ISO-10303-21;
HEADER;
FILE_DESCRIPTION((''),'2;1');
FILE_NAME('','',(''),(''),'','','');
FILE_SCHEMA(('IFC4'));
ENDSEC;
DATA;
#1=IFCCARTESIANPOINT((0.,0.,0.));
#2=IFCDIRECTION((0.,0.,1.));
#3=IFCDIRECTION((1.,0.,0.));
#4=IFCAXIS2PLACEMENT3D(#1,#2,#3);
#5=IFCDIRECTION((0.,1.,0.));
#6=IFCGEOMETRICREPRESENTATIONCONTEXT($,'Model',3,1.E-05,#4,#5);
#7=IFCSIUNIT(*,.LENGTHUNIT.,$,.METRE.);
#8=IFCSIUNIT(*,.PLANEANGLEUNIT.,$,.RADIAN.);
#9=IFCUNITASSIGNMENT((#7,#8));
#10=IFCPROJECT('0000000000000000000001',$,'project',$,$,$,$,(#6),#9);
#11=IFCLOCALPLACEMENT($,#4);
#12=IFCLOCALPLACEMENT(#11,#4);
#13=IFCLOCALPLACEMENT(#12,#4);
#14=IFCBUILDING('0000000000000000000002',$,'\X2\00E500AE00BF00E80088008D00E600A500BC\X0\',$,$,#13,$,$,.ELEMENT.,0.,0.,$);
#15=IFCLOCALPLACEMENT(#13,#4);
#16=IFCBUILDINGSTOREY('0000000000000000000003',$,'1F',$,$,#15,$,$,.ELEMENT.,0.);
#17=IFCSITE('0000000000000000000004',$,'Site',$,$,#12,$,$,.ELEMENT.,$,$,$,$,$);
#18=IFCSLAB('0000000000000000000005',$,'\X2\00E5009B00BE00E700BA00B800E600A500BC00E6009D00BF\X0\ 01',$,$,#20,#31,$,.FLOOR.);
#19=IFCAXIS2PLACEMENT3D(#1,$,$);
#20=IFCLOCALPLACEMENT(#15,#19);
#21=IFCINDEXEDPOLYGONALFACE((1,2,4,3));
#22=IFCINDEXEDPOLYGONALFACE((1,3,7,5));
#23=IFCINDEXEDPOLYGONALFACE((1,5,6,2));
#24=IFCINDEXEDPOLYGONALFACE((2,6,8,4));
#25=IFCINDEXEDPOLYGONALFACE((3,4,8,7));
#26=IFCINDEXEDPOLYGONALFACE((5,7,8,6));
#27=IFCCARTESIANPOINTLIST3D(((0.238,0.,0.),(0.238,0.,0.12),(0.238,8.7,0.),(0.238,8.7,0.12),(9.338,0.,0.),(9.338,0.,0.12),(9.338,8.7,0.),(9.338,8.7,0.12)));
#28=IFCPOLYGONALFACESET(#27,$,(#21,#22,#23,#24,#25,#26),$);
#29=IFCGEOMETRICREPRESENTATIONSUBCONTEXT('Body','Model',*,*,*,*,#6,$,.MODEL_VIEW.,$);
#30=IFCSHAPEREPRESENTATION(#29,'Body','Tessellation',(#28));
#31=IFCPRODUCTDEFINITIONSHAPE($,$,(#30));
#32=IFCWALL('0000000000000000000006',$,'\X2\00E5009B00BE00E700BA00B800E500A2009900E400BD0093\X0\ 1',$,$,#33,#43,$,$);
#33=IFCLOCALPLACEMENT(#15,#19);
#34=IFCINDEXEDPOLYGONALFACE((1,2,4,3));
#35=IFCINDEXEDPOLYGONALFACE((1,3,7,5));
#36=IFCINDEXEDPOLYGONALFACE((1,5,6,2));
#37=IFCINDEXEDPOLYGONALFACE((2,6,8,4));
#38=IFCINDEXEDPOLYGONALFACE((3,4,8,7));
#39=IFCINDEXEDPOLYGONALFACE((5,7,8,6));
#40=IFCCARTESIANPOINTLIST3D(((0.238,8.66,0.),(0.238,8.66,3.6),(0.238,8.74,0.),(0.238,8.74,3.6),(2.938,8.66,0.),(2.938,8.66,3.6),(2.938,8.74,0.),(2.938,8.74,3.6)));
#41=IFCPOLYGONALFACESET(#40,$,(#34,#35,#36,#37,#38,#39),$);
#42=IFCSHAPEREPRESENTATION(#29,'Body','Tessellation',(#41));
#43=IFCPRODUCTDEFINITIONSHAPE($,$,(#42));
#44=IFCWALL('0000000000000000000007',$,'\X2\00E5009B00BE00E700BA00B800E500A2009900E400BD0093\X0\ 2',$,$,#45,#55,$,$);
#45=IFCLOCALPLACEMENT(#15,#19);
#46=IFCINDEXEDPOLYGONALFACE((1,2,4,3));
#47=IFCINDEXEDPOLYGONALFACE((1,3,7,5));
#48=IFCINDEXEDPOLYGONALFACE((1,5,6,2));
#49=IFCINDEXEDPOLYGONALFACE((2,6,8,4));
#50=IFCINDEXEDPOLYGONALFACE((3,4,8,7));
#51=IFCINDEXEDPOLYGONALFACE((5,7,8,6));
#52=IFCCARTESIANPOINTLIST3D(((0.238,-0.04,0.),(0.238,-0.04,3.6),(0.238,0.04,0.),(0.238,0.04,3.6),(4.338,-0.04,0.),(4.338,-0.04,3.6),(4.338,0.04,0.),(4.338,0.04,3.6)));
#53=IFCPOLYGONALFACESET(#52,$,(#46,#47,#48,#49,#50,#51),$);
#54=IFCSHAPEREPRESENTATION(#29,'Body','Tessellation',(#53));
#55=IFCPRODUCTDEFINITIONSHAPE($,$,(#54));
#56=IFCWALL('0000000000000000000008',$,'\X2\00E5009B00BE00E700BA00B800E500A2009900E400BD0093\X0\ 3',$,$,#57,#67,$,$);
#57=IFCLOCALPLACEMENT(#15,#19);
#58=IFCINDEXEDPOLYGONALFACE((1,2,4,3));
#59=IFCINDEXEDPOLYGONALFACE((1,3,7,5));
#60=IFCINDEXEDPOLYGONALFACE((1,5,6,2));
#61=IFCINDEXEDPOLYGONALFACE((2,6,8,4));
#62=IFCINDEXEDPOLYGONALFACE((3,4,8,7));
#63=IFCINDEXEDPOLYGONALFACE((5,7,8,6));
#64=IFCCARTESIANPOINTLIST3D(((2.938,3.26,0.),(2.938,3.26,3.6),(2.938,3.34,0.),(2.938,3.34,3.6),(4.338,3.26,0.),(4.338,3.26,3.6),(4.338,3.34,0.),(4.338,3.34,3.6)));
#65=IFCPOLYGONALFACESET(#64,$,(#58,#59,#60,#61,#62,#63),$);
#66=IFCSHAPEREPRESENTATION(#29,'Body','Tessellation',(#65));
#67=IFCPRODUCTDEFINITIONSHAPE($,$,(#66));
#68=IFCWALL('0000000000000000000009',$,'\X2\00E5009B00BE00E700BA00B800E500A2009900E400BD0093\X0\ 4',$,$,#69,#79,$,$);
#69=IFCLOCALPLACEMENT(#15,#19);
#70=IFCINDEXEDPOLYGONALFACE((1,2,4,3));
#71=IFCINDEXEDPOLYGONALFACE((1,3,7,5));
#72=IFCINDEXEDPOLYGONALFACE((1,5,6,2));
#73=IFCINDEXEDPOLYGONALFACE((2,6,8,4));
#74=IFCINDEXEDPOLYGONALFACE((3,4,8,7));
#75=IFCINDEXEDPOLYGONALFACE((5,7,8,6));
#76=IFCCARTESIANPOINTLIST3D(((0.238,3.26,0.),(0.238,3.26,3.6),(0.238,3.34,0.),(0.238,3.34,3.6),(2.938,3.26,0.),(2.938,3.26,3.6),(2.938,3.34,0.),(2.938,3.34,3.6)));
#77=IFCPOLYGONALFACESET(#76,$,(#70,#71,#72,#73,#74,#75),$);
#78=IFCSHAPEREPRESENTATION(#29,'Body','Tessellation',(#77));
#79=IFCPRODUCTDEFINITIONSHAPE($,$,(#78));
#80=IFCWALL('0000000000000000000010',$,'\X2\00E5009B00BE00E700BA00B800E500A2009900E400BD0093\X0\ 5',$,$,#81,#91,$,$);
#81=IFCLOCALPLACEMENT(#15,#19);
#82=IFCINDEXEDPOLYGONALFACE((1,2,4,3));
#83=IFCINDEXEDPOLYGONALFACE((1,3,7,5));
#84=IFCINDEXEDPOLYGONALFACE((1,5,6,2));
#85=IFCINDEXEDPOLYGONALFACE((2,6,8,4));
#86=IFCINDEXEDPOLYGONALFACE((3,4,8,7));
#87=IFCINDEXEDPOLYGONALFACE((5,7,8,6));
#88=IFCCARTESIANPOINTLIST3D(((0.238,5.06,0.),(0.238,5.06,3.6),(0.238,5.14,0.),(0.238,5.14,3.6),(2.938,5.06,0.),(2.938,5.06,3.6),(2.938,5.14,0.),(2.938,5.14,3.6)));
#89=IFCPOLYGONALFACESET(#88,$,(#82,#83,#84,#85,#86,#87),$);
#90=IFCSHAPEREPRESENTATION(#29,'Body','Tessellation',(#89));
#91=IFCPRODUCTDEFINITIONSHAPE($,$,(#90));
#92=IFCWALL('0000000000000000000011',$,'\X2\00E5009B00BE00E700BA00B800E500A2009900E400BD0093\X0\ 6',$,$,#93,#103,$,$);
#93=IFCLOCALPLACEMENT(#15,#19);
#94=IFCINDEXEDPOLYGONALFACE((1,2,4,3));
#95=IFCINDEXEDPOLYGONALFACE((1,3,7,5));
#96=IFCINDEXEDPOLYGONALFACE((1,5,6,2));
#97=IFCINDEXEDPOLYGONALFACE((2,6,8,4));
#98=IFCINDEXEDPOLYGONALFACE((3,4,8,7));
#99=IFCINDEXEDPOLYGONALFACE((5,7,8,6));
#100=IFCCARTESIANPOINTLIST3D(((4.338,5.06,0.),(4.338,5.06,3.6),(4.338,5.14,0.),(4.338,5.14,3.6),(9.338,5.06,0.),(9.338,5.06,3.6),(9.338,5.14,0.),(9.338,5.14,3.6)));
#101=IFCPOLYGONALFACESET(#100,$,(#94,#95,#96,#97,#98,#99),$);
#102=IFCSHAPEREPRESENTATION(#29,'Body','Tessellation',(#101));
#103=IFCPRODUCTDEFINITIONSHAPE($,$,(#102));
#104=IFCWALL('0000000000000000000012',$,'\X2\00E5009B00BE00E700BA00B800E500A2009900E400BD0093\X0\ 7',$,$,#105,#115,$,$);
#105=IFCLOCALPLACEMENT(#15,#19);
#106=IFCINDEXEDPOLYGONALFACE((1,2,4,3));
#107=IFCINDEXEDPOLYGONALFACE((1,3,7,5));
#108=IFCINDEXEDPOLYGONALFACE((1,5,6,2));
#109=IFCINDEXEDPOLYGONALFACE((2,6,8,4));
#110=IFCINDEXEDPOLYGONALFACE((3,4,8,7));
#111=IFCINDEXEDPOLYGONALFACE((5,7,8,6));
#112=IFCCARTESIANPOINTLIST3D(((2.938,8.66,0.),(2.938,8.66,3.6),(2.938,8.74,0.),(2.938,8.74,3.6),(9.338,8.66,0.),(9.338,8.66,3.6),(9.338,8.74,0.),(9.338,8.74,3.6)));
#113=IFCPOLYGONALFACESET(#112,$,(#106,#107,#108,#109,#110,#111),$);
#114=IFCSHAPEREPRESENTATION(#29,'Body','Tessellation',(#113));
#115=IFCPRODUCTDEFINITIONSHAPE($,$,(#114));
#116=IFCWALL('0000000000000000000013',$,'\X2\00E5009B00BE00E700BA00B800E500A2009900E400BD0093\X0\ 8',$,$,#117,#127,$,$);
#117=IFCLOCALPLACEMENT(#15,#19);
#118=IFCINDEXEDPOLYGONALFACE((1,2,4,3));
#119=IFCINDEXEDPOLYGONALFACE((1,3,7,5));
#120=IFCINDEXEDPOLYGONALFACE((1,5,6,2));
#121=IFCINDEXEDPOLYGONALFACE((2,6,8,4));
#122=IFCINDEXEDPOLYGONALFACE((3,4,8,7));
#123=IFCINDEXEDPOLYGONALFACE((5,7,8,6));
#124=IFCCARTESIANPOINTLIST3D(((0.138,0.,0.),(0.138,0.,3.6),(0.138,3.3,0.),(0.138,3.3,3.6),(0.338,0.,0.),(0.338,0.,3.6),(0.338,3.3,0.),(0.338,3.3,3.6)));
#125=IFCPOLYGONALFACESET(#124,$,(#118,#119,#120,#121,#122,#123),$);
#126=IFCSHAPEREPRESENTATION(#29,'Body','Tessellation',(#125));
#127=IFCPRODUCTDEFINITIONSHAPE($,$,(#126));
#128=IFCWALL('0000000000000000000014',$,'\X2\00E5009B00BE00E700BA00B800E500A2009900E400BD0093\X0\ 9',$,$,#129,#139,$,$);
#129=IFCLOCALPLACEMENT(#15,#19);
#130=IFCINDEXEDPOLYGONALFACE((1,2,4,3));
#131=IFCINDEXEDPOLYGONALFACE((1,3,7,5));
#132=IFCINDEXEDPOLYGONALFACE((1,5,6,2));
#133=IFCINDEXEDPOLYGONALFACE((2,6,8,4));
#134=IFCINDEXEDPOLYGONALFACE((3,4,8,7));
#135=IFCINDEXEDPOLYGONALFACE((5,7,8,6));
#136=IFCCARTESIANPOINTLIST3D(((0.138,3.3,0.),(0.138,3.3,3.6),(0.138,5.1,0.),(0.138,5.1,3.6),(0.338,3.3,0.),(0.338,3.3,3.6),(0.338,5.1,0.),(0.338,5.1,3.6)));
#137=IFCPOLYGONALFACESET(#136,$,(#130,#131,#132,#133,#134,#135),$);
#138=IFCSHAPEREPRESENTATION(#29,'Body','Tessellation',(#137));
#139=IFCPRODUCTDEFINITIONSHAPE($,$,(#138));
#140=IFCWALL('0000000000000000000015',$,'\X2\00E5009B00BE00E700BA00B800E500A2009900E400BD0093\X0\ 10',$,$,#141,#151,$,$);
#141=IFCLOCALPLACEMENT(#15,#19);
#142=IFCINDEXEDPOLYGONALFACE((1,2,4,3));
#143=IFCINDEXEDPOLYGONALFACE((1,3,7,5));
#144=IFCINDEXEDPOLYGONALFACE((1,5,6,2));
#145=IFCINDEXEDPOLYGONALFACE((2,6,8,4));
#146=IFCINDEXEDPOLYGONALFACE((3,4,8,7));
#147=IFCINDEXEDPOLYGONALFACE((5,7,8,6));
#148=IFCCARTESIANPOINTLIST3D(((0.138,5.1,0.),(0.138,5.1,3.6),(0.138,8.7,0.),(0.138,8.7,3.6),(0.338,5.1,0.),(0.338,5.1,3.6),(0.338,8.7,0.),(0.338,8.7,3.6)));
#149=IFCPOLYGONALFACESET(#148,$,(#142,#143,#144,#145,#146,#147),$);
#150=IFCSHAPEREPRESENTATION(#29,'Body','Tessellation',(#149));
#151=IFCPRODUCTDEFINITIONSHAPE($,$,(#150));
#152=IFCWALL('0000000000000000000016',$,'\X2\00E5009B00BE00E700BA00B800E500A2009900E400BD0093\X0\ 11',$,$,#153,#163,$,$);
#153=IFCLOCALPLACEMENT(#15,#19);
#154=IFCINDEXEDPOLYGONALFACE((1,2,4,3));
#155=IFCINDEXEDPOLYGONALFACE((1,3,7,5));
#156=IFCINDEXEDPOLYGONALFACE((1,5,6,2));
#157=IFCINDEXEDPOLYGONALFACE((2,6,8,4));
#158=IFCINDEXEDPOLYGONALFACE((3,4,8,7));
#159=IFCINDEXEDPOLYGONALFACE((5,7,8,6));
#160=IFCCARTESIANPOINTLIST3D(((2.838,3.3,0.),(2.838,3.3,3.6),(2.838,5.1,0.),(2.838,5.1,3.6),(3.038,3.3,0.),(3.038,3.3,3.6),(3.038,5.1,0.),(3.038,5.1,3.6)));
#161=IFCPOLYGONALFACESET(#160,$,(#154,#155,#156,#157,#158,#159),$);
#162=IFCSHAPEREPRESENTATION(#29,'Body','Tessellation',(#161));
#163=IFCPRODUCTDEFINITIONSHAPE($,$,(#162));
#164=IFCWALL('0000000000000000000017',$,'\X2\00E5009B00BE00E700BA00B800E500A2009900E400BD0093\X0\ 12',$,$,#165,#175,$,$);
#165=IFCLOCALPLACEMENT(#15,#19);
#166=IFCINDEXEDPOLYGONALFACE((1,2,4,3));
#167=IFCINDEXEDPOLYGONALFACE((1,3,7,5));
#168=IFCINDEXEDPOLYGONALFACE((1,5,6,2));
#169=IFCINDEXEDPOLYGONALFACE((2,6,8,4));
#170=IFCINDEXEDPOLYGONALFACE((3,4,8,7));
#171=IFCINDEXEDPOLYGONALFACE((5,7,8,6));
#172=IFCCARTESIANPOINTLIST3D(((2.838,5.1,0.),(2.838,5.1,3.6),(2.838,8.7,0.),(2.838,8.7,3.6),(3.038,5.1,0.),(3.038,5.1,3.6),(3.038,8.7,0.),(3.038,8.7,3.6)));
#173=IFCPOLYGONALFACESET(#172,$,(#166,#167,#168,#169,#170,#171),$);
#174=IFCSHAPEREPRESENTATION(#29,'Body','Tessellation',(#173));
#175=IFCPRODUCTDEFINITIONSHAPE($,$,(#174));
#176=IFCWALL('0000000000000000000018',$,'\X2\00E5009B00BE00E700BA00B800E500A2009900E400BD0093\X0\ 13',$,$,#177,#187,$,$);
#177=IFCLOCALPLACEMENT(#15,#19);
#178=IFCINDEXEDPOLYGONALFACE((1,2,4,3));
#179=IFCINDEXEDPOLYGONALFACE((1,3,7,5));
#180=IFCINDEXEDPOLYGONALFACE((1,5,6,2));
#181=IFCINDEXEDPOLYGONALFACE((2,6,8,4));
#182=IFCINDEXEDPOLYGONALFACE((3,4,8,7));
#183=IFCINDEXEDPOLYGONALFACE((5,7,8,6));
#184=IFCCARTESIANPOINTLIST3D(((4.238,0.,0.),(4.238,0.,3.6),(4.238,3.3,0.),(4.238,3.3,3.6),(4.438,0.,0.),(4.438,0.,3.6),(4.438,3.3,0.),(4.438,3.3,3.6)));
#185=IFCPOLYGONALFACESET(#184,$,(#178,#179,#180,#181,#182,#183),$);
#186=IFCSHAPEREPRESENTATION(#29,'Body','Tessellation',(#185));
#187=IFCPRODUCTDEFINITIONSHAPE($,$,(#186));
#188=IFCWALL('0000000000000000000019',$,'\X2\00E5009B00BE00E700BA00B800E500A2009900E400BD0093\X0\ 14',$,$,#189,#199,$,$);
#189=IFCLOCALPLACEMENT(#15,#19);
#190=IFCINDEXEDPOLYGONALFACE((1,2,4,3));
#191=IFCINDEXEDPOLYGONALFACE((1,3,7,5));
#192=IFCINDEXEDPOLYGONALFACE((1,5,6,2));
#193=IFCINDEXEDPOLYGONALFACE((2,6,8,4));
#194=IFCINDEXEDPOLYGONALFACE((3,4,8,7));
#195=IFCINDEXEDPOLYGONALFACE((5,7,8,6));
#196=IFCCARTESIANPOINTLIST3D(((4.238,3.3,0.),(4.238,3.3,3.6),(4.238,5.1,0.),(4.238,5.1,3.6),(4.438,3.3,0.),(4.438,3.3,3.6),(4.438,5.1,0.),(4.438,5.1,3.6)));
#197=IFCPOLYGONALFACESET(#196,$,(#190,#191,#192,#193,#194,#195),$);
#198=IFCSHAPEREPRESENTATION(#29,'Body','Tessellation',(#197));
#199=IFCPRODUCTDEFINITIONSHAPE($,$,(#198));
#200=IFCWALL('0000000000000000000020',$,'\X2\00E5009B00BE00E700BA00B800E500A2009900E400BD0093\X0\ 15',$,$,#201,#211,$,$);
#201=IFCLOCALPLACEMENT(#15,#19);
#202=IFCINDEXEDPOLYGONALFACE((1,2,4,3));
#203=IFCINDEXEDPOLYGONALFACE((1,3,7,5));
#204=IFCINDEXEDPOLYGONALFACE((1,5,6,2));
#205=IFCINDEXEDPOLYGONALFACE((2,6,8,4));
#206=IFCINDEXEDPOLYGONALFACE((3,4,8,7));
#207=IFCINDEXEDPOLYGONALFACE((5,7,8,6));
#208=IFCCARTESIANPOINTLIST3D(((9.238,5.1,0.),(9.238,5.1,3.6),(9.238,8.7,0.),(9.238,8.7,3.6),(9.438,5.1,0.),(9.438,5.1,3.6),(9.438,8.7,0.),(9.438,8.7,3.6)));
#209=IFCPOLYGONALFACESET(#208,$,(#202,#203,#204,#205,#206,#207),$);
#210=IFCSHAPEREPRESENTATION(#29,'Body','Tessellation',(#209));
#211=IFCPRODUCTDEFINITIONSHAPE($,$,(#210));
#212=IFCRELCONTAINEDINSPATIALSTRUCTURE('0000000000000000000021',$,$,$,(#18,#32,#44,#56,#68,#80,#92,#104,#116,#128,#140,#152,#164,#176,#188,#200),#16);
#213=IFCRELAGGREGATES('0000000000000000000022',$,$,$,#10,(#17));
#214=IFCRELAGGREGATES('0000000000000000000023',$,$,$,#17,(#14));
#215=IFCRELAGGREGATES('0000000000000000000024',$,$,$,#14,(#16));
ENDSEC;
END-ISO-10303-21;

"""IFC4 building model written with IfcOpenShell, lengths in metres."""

from ifc_helpers import new_model, si_unit, direction, frame, frame_2d, origin_with_axes, place, context, subcontext, project, spatial, rectangle, extrude, element, save


model = new_model("IFC4")

# Units and contexts
model_context = context("Model", 3, precision=1e-05, world=origin_with_axes(), true_north=direction((0.0, 1.0, 0.0)))
body_context = subcontext(model_context, "Body", "Model", "MODEL_VIEW")
ifc_project = project(units=[si_unit("LENGTHUNIT", "METRE"), si_unit("PLANEANGLEUNIT", "RADIAN")], contexts=[model_context])

# Site, building, storey
placement = place(None, origin_with_axes())
site_placement = place(placement, origin_with_axes())
site = spatial("IfcSite", under=ifc_project, at=site_placement, Name="Site", CompositionType="ELEMENT")
building_placement = place(site_placement, origin_with_axes())
building = spatial("IfcBuilding", under=site, at=building_placement, Name="å®¿è\u0088\u008dæ¥¼", CompositionType="ELEMENT", ElevationOfRefHeight=0.0, ElevationOfTerrain=0.0)
storey_placement = place(building_placement, origin_with_axes())
storey = spatial("IfcBuildingStorey", under=building, at=storey_placement, Name="1F", CompositionType="ELEMENT", Elevation=0.0)

# Slab
slab_placement = place(storey_placement, frame((4.788, 4.35, 0.0), z_axis=(0.0, 0.0, 1.0), x_axis=(1.0, 0.0, 0.0)))
element("IfcSlab", 1, at=slab_placement, inside=storey, Name="å\u009b¾çº¸æ¥¼æ\u009d¿ 01", PredefinedType="FLOOR", context=body_context, shape_type="SweptSolid", body=[
    extrude(rectangle(XDim=9.1, YDim=8.7, at=frame_2d((0.0, 0.0), x_axis=(1.0, 0.0, 0.0))), frame((0.0, 0.0, 0.0), z_axis=(0.0, 0.0, 1.0)), (0.0, 0.0, 1.0), 0.12),
])

# Walls
wall_1_placement = place(storey_placement, frame((1.588, 8.7, 0.0), z_axis=(0.0, 0.0, 1.0), x_axis=(1.0, 0.0, 0.0)))
element("IfcWall", 2, at=wall_1_placement, inside=storey, Name="å\u009b¾çº¸å¢\u0099ä½\u0093 1", context=body_context, shape_type="SweptSolid", body=[
    extrude(rectangle(XDim=2.7, YDim=0.0801, at=frame_2d((0.0, 0.0), x_axis=(1.0, 0.0, 0.0))), frame((0.0, 0.0, 0.0), z_axis=(0.0, 0.0, 1.0)), (0.0, 0.0, 1.0), 3.6),
])
wall_2_placement = place(storey_placement, frame((2.288, 0.0, 0.0), z_axis=(0.0, 0.0, 1.0), x_axis=(1.0, 0.0, 0.0)))
element("IfcWall", 3, at=wall_2_placement, inside=storey, Name="å\u009b¾çº¸å¢\u0099ä½\u0093 2", context=body_context, shape_type="SweptSolid", body=[
    extrude(rectangle(XDim=4.1, YDim=0.0801, at=frame_2d((0.0, 0.0), x_axis=(1.0, 0.0, 0.0))), frame((0.0, 0.0, 0.0), z_axis=(0.0, 0.0, 1.0)), (0.0, 0.0, 1.0), 3.6),
])
wall_3_placement = place(storey_placement, frame((3.638, 3.3, 0.0), z_axis=(0.0, 0.0, 1.0), x_axis=(1.0, 0.0, 0.0)))
element("IfcWall", 4, at=wall_3_placement, inside=storey, Name="å\u009b¾çº¸å¢\u0099ä½\u0093 3", context=body_context, shape_type="SweptSolid", body=[
    extrude(rectangle(XDim=1.4, YDim=0.0801, at=frame_2d((0.0, 0.0), x_axis=(1.0, 0.0, 0.0))), frame((0.0, 0.0, 0.0), z_axis=(0.0, 0.0, 1.0)), (0.0, 0.0, 1.0), 3.6),
])
for number, where, z_axis, x_axis, name in (
    (5, (1.588, 3.3, 0.0), (0.0, 0.0, 1.0), (1.0, 0.0, 0.0), "å\u009b¾çº¸å¢\u0099ä½\u0093 4"),
    (6, (1.588, 5.1, 0.0), (0.0, 0.0, 1.0), (1.0, 0.0, 0.0), "å\u009b¾çº¸å¢\u0099ä½\u0093 5"),
):
    element("IfcWall", number, at=place(storey_placement, frame(where, z_axis=z_axis, x_axis=x_axis)), inside=storey, Name=name, context=body_context, shape_type="SweptSolid", body=[
        extrude(rectangle(XDim=2.7, YDim=0.0801, at=frame_2d((0.0, 0.0), x_axis=(1.0, 0.0, 0.0))), frame((0.0, 0.0, 0.0), z_axis=(0.0, 0.0, 1.0)), (0.0, 0.0, 1.0), 3.6),
    ])
wall_4_placement = place(storey_placement, frame((6.838, 5.1, 0.0), z_axis=(0.0, 0.0, 1.0), x_axis=(1.0, 0.0, 0.0)))
element("IfcWall", 7, at=wall_4_placement, inside=storey, Name="å\u009b¾çº¸å¢\u0099ä½\u0093 6", context=body_context, shape_type="SweptSolid", body=[
    extrude(rectangle(XDim=5.0, YDim=0.0801, at=frame_2d((0.0, 0.0), x_axis=(1.0, 0.0, 0.0))), frame((0.0, 0.0, 0.0), z_axis=(0.0, 0.0, 1.0)), (0.0, 0.0, 1.0), 3.6),
])
wall_5_placement = place(storey_placement, frame((6.138, 8.7, 0.0), z_axis=(0.0, 0.0, 1.0), x_axis=(-1.0, 0.0, 0.0)))
element("IfcWall", 8, at=wall_5_placement, inside=storey, Name="å\u009b¾çº¸å¢\u0099ä½\u0093 7", context=body_context, shape_type="SweptSolid", body=[
    extrude(rectangle(XDim=6.4, YDim=0.0801, at=frame_2d((0.0, 0.0), x_axis=(1.0, 0.0, 0.0))), frame((0.0, 0.0, 0.0), z_axis=(0.0, 0.0, 1.0)), (0.0, 0.0, 1.0), 3.6),
])
wall_6_placement = place(storey_placement, frame((0.238, 1.65, 0.0), z_axis=(0.0, 0.0, 1.0), x_axis=(0.0, 1.0, 0.0)))
element("IfcWall", 9, at=wall_6_placement, inside=storey, Name="å\u009b¾çº¸å¢\u0099ä½\u0093 8", context=body_context, shape_type="SweptSolid", body=[
    extrude(rectangle(XDim=3.3, YDim=0.2, at=frame_2d((0.0, 0.0), x_axis=(1.0, 0.0, 0.0))), frame((0.0, 0.0, 0.0), z_axis=(0.0, 0.0, 1.0)), (0.0, 0.0, 1.0), 3.6),
])
wall_7_placement = place(storey_placement, frame((0.238, 4.2, 0.0), z_axis=(0.0, 0.0, 1.0), x_axis=(0.0, 1.0, 0.0)))
element("IfcWall", 10, at=wall_7_placement, inside=storey, Name="å\u009b¾çº¸å¢\u0099ä½\u0093 9", context=body_context, shape_type="SweptSolid", body=[
    extrude(rectangle(XDim=1.8, YDim=0.2, at=frame_2d((0.0, 0.0), x_axis=(1.0, 0.0, 0.0))), frame((0.0, 0.0, 0.0), z_axis=(0.0, 0.0, 1.0)), (0.0, 0.0, 1.0), 3.6),
])
wall_8_placement = place(storey_placement, frame((0.238, 6.9, 0.0), z_axis=(0.0, 0.0, 1.0), x_axis=(0.0, 1.0, 0.0)))
element("IfcWall", 11, at=wall_8_placement, inside=storey, Name="å\u009b¾çº¸å¢\u0099ä½\u0093 10", context=body_context, shape_type="SweptSolid", body=[
    extrude(rectangle(XDim=3.6, YDim=0.2, at=frame_2d((0.0, 0.0), x_axis=(1.0, 0.0, 0.0))), frame((0.0, 0.0, 0.0), z_axis=(0.0, 0.0, 1.0)), (0.0, 0.0, 1.0), 3.6),
])
wall_9_placement = place(storey_placement, frame((2.938, 4.2, 0.0), z_axis=(0.0, 0.0, 1.0), x_axis=(0.0, 1.0, 0.0)))
element("IfcWall", 12, at=wall_9_placement, inside=storey, Name="å\u009b¾çº¸å¢\u0099ä½\u0093 11", context=body_context, shape_type="SweptSolid", body=[
    extrude(rectangle(XDim=1.8, YDim=0.2, at=frame_2d((0.0, 0.0), x_axis=(1.0, 0.0, 0.0))), frame((0.0, 0.0, 0.0), z_axis=(0.0, 0.0, 1.0)), (0.0, 0.0, 1.0), 3.6),
])
wall_10_placement = place(storey_placement, frame((2.938, 6.9, 0.0), z_axis=(0.0, 0.0, 1.0), x_axis=(0.0, 1.0, 0.0)))
element("IfcWall", 13, at=wall_10_placement, inside=storey, Name="å\u009b¾çº¸å¢\u0099ä½\u0093 12", context=body_context, shape_type="SweptSolid", body=[
    extrude(rectangle(XDim=3.6, YDim=0.2, at=frame_2d((0.0, 0.0), x_axis=(1.0, 0.0, 0.0))), frame((0.0, 0.0, 0.0), z_axis=(0.0, 0.0, 1.0)), (0.0, 0.0, 1.0), 3.6),
])
wall_11_placement = place(storey_placement, frame((4.338, 1.65, 0.0), z_axis=(0.0, 0.0, 1.0), x_axis=(0.0, 1.0, 0.0)))
element("IfcWall", 14, at=wall_11_placement, inside=storey, Name="å\u009b¾çº¸å¢\u0099ä½\u0093 13", context=body_context, shape_type="SweptSolid", body=[
    extrude(rectangle(XDim=3.3, YDim=0.2, at=frame_2d((0.0, 0.0), x_axis=(1.0, 0.0, 0.0))), frame((0.0, 0.0, 0.0), z_axis=(0.0, 0.0, 1.0)), (0.0, 0.0, 1.0), 3.6),
])
wall_12_placement = place(storey_placement, frame((4.338, 4.2, 0.0), z_axis=(0.0, 0.0, 1.0), x_axis=(0.0, 1.0, 0.0)))
element("IfcWall", 15, at=wall_12_placement, inside=storey, Name="å\u009b¾çº¸å¢\u0099ä½\u0093 14", context=body_context, shape_type="SweptSolid", body=[
    extrude(rectangle(XDim=1.8, YDim=0.2, at=frame_2d((0.0, 0.0), x_axis=(1.0, 0.0, 0.0))), frame((0.0, 0.0, 0.0), z_axis=(0.0, 0.0, 1.0)), (0.0, 0.0, 1.0), 3.6),
])
wall_13_placement = place(storey_placement, frame((9.338, 6.9, 0.0), z_axis=(0.0, 0.0, 1.0), x_axis=(0.0, 1.0, 0.0)))
element("IfcWall", 16, at=wall_13_placement, inside=storey, Name="å\u009b¾çº¸å¢\u0099ä½\u0093 15", context=body_context, shape_type="SweptSolid", body=[
    extrude(rectangle(XDim=3.6, YDim=0.2, at=frame_2d((0.0, 0.0), x_axis=(1.0, 0.0, 0.0))), frame((0.0, 0.0, 0.0), z_axis=(0.0, 0.0, 1.0)), (0.0, 0.0, 1.0), 3.6),
])

save(model, "model.ifc")
